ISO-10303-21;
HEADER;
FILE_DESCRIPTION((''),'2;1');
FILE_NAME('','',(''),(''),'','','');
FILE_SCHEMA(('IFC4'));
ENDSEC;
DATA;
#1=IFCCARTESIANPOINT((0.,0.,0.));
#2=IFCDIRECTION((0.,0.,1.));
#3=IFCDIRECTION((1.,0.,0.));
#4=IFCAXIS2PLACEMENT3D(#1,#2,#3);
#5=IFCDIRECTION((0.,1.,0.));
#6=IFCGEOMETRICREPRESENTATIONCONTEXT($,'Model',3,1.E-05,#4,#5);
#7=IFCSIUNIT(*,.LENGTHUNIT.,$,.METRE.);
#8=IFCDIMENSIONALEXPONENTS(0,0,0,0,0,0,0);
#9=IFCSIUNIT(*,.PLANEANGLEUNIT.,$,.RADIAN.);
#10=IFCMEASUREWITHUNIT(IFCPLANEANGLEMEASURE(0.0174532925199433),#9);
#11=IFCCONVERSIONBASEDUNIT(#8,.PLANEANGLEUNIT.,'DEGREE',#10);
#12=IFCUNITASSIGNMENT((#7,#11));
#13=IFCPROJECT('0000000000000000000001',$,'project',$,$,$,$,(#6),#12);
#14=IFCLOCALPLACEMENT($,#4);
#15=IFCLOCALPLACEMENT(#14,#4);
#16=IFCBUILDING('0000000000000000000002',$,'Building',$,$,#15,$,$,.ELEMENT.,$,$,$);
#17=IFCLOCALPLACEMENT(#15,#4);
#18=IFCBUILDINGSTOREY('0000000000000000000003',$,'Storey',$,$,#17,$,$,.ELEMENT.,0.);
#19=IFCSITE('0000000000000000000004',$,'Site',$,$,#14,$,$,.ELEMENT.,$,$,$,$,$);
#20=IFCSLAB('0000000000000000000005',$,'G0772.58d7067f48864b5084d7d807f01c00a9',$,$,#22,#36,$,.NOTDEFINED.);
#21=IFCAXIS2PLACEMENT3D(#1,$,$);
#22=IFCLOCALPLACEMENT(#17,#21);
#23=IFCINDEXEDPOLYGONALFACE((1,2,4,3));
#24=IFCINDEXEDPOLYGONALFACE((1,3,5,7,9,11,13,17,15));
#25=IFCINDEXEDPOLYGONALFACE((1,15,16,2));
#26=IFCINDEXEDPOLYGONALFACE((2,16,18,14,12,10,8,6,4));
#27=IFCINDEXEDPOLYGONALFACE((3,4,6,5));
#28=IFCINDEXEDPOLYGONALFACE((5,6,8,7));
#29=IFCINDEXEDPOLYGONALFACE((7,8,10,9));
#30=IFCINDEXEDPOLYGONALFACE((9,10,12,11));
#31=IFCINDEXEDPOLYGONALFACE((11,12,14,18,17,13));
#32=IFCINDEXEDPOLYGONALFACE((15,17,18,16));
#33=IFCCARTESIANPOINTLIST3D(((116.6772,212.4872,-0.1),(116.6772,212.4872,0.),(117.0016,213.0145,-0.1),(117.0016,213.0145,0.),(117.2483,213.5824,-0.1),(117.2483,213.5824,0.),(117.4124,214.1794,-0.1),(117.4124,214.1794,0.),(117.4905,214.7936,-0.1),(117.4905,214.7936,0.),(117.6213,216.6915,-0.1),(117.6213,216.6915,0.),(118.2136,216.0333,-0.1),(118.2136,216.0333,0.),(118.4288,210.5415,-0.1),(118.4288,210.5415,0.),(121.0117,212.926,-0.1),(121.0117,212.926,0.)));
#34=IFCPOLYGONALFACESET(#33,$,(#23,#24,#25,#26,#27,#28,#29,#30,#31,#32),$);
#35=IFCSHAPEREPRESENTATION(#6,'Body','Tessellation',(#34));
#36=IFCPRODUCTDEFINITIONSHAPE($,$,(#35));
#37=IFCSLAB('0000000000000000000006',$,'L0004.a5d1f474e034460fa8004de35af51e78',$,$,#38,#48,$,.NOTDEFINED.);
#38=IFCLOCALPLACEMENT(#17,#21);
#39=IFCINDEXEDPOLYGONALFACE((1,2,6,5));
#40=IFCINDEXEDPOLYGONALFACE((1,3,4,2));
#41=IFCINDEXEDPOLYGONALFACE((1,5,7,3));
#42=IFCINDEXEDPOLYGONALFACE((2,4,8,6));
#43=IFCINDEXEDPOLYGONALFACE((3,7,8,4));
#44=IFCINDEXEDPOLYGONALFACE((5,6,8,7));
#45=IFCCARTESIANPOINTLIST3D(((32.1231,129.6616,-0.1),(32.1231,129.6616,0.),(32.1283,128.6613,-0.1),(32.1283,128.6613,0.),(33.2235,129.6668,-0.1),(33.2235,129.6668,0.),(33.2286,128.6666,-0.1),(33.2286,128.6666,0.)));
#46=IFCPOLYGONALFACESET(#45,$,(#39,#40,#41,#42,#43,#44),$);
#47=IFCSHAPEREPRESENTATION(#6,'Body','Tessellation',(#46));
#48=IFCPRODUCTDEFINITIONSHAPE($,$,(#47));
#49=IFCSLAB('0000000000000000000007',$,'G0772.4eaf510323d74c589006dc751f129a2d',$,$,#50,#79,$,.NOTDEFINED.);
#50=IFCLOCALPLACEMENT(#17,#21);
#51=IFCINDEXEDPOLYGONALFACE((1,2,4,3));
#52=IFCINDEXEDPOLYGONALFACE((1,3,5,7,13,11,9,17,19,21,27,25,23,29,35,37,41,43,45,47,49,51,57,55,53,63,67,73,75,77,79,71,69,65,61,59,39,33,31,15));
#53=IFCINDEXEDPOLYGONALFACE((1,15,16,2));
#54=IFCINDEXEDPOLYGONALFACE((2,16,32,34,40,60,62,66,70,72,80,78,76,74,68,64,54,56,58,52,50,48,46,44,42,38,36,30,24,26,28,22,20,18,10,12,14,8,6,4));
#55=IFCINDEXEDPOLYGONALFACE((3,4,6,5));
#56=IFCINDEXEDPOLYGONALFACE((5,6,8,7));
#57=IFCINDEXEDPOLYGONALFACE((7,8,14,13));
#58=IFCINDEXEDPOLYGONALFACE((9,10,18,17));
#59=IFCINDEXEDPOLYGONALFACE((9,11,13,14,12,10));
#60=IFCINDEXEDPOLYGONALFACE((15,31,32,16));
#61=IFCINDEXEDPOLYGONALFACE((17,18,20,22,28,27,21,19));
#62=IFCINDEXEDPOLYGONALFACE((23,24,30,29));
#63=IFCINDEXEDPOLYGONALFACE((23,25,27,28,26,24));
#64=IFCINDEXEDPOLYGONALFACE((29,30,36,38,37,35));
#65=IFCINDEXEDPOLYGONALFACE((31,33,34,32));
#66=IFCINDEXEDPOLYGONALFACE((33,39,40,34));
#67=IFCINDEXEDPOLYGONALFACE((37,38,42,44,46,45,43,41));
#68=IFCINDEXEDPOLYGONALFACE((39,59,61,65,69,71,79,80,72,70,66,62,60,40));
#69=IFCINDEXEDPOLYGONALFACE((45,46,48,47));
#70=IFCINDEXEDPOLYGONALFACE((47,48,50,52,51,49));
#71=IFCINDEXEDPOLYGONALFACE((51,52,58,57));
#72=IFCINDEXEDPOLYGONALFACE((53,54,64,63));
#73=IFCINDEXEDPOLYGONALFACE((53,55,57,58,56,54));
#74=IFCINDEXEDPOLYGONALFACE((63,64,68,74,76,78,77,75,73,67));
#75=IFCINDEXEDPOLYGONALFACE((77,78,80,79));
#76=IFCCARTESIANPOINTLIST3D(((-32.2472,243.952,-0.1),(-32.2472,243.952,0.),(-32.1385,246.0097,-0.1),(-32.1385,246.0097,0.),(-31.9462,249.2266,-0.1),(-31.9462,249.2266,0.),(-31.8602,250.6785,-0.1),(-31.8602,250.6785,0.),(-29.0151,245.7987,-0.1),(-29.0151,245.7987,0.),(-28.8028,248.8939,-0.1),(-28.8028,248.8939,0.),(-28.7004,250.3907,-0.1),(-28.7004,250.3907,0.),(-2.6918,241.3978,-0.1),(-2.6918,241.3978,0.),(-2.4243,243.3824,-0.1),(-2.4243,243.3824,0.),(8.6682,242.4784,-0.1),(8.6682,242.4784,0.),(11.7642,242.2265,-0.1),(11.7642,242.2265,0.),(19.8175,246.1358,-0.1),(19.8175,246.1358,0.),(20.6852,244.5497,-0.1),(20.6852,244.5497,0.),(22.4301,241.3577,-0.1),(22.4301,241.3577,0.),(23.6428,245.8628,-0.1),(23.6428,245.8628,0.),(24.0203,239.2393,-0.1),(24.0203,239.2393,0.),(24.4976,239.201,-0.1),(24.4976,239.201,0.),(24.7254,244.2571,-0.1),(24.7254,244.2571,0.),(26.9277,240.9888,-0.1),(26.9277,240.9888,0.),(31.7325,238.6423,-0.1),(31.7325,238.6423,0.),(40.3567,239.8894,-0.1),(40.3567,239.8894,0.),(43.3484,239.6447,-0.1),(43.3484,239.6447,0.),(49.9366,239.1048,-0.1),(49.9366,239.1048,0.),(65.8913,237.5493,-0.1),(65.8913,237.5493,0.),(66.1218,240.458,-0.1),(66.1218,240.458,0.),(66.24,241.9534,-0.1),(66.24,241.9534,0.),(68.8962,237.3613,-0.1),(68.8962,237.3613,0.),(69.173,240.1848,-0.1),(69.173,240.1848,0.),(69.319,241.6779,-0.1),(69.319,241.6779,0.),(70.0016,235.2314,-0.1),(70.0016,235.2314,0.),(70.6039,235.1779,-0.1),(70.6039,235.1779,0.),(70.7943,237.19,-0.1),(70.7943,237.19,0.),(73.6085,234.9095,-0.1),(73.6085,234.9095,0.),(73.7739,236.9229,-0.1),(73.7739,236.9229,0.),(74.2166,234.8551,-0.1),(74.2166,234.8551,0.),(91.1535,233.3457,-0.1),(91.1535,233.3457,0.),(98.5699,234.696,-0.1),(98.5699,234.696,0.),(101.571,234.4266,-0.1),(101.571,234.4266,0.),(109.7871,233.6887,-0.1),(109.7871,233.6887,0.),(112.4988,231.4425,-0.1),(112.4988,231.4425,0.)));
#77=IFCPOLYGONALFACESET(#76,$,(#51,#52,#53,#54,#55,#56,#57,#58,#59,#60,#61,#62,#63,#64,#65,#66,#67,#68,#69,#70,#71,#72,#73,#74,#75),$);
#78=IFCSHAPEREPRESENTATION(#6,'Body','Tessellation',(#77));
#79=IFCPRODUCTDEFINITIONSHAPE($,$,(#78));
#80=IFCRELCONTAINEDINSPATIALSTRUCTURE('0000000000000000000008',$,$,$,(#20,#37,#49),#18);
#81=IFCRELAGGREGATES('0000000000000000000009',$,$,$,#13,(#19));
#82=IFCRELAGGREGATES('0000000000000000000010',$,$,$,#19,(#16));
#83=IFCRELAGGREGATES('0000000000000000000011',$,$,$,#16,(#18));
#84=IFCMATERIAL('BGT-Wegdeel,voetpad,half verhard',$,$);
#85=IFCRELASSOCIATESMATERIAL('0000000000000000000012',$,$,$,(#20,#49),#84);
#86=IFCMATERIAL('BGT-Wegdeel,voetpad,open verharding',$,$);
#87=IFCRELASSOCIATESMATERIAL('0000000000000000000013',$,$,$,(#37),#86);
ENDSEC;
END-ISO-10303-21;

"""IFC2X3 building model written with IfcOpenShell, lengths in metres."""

from ifc_helpers import new_model, entity, si_unit, converted_unit, direction, frame, origin_with_axes, place, context, project, spatial, polyline, outline, extrude, material, element, save


model = new_model("IFC2X3")

# Units and contexts
model_context = context("Model", 3, precision=1e-05, world=origin_with_axes(), true_north=direction((0.0, 1.0, 0.0)))
ifc_project = project(units=[si_unit("LENGTHUNIT", "METRE"), converted_unit("PLANEANGLEUNIT", "DEGREE", entity("IfcPlaneAngleMeasure", 0.0174532925199433), si_unit("PLANEANGLEUNIT", "RADIAN"), dimensions=[0, 0, 0, 0, 0, 0, 0])], contexts=[model_context])

# Site, building, storey
site_placement = place(None, origin_with_axes())
site = spatial("IfcSite", under=ifc_project, at=site_placement, Name="Site", CompositionType="ELEMENT")
building_placement = place(site_placement, origin_with_axes())
building = spatial("IfcBuilding", under=site, at=building_placement, Name="Building", CompositionType="ELEMENT")
storey_placement = place(building_placement, origin_with_axes())
storey = spatial("IfcBuildingStorey", under=building, at=storey_placement, Name="Storey", CompositionType="ELEMENT", Elevation=0.0)

# Slabs
ifc_material_1 = material(Name="BGT-Wegdeel,voetpad,half verhard")
slab_1_placement = place(storey_placement, frame((0.0, 0.0, -0.1), z_axis=(0.0, 0.0, 1.0), x_axis=(1.0, 0.0, 0.0)))
element("IfcSlab", 1, at=slab_1_placement, inside=storey, material=ifc_material_1, Name="G0772.58d7067f48864b5084d7d807f01c00a9", PredefinedType="NOTDEFINED", context=model_context, shape_type="SweptSolid", body=[
    extrude(outline(polyline([(121.0117, 212.926), (118.4288, 210.5415), (116.6772, 212.4872), (117.0016, 213.0145), (117.2483, 213.5824), (117.4124, 214.1794), (117.4905, 214.7936), (117.6213, 216.6915), (118.2136, 216.0333), (121.0117, 212.926)])), origin_with_axes(), (0.0, 0.0, 1.0), 0.1),
])
ifc_material_2 = material(Name="BGT-Wegdeel,voetpad,open verharding")
slab_2_placement = place(storey_placement, frame((0.0, 0.0, -0.1), z_axis=(0.0, 0.0, 1.0), x_axis=(1.0, 0.0, 0.0)))
element("IfcSlab", 2, at=slab_2_placement, inside=storey, material=ifc_material_2, Name="L0004.a5d1f474e034460fa8004de35af51e78", PredefinedType="NOTDEFINED", context=model_context, shape_type="SweptSolid", body=[
    extrude(outline(polyline([(33.2235, 129.6668), (33.2286, 128.6666), (32.1283, 128.6613), (32.1231, 129.6616), (33.2235, 129.6668)])), origin_with_axes(), (0.0, 0.0, 1.0), 0.1),
])
slab_3_placement = place(storey_placement, frame((0.0, 0.0, -0.1), z_axis=(0.0, 0.0, 1.0), x_axis=(1.0, 0.0, 0.0)))
element("IfcSlab", 3, at=slab_3_placement, inside=storey, material=ifc_material_1, Name="G0772.4eaf510323d74c589006dc751f129a2d", PredefinedType="NOTDEFINED", context=model_context, shape_type="SweptSolid", body=[
    extrude(outline(polyline([(91.1535, 233.3457), (74.2166, 234.8551), (73.6085, 234.9095), (70.6039, 235.1779), (70.0016, 235.2314), (31.7325, 238.6423), (24.4976, 239.201), (24.0203, 239.2393), (-2.6918, 241.3978), (-32.2472, 243.952), (-32.1385, 246.0097), (-31.9462, 249.2266), (-31.8602, 250.6785), (-28.7004, 250.3907), (-28.8028, 248.8939), (-29.0151, 245.7987), (-2.4243, 243.3824), (8.6682, 242.4784), (11.7642, 242.2265), (22.4301, 241.3577), (20.6852, 244.5497), (19.8175, 246.1358), (23.6428, 245.8628), (24.7254, 244.2571), (26.9277, 240.9888), (40.3567, 239.8894), (43.3484, 239.6447), (49.9366, 239.1048), (65.8913, 237.5493), (66.1218, 240.458), (66.24, 241.9534), (69.319, 241.6779), (69.173, 240.1848), (68.8962, 237.3613), (70.7943, 237.19), (73.7739, 236.9229), (98.5699, 234.696), (101.571, 234.4266), (109.7871, 233.6887), (112.4988, 231.4425), (91.1535, 233.3457)])), origin_with_axes(), (0.0, 0.0, 1.0), 0.1),
])

save(model, "model.ifc")
